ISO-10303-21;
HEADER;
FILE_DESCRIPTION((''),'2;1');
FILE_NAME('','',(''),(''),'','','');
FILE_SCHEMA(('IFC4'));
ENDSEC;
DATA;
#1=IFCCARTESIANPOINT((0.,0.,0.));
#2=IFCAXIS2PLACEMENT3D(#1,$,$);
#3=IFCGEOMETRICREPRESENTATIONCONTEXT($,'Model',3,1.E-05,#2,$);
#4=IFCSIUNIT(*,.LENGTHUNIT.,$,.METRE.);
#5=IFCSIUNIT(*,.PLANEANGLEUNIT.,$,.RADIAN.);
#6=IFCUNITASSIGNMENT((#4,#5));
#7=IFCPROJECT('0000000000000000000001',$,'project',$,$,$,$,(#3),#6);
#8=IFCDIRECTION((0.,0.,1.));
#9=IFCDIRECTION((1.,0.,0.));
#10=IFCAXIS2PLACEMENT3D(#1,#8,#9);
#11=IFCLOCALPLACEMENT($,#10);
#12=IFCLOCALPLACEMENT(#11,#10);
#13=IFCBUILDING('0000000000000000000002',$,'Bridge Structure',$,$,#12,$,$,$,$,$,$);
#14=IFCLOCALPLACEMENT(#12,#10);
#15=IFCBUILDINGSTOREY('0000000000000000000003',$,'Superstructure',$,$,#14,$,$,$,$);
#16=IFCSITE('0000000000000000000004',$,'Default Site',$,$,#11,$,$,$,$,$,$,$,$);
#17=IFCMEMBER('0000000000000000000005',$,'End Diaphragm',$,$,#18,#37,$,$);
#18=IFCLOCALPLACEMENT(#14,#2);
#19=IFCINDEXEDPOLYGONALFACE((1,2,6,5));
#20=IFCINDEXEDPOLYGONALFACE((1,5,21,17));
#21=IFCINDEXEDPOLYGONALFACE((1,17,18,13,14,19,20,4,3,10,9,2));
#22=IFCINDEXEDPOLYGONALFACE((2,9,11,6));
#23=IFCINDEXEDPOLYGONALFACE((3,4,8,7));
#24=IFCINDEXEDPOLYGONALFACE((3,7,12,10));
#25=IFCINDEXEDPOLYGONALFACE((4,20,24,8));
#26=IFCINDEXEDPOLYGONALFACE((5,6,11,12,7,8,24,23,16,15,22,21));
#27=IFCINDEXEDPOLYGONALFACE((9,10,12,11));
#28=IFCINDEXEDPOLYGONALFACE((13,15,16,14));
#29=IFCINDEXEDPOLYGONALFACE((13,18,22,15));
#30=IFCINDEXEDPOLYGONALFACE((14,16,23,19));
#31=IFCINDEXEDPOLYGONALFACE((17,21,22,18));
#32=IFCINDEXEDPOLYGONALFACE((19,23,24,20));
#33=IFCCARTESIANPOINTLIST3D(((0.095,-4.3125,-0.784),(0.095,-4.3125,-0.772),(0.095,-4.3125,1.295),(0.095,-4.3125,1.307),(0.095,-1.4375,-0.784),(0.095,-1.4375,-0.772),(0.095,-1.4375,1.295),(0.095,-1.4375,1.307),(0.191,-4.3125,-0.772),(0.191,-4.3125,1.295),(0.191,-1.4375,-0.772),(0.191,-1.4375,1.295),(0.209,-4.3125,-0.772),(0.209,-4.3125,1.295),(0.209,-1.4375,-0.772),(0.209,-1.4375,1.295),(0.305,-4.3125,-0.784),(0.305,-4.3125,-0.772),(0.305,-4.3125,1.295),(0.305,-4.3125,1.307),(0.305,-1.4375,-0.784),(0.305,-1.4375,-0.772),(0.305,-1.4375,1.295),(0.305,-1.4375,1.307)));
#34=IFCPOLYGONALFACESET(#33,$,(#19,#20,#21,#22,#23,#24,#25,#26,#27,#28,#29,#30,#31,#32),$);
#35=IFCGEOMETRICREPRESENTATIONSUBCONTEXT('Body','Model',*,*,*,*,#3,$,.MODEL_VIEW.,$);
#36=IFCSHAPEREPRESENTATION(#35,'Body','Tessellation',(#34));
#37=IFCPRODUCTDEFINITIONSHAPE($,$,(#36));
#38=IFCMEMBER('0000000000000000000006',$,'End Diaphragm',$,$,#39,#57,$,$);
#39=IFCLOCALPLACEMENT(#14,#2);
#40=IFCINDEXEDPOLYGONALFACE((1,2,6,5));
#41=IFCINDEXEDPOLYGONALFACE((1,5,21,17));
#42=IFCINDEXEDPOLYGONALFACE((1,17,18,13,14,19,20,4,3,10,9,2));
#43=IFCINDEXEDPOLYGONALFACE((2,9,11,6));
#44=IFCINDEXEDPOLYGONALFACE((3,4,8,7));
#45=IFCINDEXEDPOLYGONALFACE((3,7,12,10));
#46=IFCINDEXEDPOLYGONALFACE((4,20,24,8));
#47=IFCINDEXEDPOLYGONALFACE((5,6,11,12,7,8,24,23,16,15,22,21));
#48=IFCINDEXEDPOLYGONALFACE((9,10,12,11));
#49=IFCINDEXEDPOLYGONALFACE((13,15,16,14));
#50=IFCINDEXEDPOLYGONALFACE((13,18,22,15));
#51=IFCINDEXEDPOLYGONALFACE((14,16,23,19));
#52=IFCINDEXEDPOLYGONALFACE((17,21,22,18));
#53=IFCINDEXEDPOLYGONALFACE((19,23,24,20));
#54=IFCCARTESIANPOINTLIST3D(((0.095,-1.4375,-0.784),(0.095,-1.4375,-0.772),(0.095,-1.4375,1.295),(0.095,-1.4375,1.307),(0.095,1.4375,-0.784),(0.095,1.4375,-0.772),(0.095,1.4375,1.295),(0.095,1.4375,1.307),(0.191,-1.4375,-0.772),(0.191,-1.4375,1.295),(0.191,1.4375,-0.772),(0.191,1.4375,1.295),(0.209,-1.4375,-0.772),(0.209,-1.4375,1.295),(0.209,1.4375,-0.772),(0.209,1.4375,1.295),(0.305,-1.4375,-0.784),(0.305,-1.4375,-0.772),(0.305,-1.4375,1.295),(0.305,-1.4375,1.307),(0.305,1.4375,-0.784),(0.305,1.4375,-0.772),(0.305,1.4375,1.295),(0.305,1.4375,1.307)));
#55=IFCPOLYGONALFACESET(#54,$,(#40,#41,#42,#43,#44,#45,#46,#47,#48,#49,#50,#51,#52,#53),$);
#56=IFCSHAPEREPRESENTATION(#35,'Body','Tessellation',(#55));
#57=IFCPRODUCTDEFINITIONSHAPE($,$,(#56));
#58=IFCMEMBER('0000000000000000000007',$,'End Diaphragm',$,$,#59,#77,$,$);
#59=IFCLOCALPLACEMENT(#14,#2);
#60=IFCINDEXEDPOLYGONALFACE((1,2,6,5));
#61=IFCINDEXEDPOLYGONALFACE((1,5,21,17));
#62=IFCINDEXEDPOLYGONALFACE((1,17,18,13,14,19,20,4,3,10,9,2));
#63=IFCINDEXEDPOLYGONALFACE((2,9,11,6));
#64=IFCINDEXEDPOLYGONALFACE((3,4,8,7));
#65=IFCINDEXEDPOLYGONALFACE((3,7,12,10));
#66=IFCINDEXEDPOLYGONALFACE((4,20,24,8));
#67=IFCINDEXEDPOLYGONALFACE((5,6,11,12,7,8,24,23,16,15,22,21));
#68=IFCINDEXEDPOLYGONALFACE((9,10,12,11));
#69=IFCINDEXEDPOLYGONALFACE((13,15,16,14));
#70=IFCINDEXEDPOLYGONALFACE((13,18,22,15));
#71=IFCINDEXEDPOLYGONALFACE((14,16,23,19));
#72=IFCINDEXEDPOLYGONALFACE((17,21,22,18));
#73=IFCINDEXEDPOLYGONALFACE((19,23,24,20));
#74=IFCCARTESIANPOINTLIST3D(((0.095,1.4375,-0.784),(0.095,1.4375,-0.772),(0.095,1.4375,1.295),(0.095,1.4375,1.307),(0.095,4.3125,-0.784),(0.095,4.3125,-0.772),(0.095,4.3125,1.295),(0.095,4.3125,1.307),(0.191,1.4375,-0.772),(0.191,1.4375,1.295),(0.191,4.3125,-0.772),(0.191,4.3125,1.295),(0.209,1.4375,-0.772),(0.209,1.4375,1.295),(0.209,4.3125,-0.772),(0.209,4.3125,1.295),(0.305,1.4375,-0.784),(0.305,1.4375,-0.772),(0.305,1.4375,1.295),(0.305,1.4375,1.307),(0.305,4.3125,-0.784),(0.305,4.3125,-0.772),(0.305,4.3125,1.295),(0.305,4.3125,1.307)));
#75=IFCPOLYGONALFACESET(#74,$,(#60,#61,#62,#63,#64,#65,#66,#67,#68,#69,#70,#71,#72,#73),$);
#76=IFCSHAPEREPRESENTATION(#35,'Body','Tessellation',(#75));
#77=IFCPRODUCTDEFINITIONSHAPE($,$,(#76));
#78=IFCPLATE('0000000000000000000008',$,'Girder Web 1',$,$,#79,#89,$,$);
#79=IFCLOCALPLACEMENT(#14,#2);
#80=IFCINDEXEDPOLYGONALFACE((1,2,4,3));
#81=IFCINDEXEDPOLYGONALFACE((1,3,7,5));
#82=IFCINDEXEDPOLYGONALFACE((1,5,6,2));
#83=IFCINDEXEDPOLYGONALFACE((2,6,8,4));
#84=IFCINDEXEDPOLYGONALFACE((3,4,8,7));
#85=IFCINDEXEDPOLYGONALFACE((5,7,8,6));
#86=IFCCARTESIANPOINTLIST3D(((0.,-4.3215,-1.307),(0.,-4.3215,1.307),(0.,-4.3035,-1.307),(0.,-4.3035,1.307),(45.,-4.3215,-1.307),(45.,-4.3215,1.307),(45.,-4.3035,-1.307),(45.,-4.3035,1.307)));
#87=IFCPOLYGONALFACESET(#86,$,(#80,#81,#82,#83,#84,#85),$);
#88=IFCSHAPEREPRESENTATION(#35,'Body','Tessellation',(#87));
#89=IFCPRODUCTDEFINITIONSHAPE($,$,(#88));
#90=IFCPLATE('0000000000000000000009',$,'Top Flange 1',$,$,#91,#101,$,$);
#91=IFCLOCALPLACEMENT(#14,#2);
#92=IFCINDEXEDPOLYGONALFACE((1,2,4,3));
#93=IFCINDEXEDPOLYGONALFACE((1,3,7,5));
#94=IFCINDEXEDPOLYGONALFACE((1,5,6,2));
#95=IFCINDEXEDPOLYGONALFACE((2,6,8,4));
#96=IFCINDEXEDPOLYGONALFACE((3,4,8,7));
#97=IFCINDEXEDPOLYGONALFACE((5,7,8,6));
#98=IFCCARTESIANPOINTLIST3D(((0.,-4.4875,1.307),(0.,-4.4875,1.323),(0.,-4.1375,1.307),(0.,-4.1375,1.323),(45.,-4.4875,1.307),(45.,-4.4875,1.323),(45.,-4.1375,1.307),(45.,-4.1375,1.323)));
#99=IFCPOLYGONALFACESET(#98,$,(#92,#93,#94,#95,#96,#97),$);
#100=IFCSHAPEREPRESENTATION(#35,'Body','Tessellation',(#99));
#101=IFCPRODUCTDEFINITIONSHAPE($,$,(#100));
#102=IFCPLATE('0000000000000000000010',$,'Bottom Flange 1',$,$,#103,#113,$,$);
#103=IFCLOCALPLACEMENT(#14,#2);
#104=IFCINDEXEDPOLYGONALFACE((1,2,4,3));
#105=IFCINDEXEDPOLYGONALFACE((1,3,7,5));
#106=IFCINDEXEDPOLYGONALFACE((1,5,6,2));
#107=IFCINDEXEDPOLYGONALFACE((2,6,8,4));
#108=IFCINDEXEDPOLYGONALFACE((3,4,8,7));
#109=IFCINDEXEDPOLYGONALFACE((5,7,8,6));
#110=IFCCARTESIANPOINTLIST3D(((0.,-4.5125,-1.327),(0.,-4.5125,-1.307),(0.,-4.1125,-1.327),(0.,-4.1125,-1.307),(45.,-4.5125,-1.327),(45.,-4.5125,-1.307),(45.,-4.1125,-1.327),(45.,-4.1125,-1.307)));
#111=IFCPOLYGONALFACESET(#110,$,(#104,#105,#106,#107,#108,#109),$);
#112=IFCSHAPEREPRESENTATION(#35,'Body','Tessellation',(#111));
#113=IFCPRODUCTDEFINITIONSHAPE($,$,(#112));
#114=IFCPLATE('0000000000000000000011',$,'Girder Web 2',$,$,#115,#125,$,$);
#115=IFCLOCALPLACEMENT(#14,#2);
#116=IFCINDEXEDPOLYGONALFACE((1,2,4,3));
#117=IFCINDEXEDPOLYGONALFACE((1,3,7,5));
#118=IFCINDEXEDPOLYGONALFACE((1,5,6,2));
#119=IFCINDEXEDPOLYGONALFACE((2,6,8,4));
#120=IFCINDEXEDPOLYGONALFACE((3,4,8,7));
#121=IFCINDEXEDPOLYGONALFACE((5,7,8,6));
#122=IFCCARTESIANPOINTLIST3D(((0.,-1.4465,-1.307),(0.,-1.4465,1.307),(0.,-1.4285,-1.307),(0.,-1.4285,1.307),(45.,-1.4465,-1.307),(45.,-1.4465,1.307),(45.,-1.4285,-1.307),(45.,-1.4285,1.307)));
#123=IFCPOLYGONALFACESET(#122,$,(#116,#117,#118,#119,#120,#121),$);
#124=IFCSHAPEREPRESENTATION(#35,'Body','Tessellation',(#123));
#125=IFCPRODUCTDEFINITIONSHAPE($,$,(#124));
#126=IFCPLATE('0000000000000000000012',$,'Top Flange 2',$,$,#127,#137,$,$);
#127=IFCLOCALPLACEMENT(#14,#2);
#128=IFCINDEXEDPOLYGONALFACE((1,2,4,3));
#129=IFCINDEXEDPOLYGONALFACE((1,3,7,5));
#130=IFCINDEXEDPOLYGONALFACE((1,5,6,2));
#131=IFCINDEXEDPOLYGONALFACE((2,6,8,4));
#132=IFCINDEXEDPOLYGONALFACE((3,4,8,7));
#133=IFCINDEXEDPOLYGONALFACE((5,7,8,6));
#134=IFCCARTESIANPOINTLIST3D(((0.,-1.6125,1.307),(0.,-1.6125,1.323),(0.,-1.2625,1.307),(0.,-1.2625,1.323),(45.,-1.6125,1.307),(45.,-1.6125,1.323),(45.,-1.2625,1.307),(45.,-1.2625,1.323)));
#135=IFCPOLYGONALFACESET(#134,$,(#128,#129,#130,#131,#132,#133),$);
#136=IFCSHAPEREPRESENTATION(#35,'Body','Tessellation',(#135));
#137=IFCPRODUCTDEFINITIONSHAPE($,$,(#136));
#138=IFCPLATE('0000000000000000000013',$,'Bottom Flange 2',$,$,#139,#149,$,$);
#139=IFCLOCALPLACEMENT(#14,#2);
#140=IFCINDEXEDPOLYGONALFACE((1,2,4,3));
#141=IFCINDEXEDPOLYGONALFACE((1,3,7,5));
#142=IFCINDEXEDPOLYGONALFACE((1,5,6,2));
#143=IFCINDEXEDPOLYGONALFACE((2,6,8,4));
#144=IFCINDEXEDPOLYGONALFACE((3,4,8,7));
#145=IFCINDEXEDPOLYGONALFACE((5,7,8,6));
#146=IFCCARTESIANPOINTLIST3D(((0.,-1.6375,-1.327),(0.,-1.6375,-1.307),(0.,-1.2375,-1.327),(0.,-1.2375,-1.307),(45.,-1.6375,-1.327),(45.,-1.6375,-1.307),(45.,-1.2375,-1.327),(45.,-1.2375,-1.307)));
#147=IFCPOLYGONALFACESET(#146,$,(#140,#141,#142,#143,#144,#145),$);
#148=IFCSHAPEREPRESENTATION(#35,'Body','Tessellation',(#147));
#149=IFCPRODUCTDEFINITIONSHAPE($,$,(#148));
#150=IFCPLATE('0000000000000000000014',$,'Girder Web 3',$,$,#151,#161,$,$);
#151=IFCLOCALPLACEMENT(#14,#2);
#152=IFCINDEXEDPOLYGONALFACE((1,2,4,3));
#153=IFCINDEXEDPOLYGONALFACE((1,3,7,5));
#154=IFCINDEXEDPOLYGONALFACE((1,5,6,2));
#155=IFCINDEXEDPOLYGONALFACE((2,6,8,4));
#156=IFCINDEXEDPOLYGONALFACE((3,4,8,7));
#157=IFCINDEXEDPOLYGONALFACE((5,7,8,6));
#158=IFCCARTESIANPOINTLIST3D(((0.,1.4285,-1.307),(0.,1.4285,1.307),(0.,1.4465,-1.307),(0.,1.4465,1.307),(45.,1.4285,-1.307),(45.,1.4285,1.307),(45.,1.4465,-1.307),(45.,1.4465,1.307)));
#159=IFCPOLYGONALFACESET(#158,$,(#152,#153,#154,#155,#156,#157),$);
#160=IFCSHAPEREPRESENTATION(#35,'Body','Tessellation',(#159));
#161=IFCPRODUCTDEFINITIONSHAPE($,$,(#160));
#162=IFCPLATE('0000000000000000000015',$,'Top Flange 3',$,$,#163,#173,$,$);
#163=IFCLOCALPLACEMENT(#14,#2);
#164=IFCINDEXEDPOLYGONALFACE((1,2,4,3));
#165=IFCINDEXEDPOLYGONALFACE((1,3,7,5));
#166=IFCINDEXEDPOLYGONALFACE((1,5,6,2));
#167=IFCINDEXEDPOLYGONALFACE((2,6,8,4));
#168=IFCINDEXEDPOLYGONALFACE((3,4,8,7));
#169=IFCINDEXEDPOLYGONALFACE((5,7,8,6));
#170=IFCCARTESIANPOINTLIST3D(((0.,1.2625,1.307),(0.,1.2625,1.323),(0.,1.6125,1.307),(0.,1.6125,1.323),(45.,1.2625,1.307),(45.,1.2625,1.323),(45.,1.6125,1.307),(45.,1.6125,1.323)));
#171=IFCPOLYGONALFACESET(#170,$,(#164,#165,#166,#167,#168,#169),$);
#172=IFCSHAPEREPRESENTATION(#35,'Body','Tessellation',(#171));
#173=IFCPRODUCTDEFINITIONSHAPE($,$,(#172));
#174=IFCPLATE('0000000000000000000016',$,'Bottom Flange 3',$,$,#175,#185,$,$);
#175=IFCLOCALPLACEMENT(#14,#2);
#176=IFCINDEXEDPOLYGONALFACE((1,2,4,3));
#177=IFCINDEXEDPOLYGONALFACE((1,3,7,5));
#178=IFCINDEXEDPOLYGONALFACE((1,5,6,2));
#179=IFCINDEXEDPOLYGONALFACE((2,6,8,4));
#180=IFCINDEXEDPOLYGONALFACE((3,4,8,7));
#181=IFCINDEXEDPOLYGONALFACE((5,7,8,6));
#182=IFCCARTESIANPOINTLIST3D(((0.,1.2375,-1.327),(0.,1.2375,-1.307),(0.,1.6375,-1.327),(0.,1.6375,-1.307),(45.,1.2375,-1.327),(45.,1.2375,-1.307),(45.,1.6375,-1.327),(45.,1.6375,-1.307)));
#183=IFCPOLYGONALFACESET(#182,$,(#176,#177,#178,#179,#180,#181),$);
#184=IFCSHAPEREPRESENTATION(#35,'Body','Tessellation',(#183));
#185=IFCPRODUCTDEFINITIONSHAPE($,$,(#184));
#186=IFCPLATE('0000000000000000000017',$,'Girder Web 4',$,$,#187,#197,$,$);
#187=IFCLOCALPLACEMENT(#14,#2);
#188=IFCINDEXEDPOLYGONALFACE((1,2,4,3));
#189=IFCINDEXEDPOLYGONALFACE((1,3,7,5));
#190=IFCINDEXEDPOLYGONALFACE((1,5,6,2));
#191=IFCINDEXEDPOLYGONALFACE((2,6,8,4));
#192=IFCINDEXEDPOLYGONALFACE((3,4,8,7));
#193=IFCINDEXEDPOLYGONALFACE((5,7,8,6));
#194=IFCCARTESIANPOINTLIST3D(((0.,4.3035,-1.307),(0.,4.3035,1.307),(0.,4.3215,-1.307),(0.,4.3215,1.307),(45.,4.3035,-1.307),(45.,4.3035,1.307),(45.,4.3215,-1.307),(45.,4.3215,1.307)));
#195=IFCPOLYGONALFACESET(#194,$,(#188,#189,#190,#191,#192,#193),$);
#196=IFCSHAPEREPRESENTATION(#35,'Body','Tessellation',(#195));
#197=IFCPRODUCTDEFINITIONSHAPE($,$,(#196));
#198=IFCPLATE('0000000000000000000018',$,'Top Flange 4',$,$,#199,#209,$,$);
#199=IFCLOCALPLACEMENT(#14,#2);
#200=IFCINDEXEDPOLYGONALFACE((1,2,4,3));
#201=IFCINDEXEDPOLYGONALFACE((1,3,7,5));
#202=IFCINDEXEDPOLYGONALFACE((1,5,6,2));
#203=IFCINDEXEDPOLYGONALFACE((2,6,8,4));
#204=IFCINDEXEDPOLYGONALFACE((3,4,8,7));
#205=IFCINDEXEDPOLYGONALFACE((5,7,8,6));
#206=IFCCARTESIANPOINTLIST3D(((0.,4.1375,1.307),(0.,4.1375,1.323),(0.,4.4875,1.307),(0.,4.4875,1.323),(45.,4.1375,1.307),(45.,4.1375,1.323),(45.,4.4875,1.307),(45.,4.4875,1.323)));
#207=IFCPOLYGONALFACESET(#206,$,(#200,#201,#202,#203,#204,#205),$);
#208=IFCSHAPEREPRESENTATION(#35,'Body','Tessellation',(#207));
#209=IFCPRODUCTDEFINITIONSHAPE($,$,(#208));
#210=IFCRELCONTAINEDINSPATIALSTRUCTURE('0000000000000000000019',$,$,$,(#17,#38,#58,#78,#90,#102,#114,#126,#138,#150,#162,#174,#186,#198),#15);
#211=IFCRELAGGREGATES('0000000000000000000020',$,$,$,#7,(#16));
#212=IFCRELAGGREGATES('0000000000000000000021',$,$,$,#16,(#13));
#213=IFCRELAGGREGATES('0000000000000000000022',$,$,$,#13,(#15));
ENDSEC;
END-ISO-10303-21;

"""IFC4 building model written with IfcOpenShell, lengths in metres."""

from ifc_helpers import new_model, si_unit, frame, origin, origin_with_axes, origin_2d_with_axis, place, context, subcontext, project, spatial, rectangle, i_section, extrude, element, save


model = new_model("IFC4")

# Units and contexts
model_context = context("Model", 3, precision=1e-05, world=origin())
body_context = subcontext(model_context, "Body", "Model", "MODEL_VIEW")
ifc_project = project(units=[si_unit("LENGTHUNIT", "METRE"), si_unit("PLANEANGLEUNIT", "RADIAN")], contexts=[model_context])

# Site, building, storey
site_placement = place(None, origin_with_axes())
site = spatial("IfcSite", under=ifc_project, at=site_placement, Name="Default Site")
building_placement = place(site_placement, origin_with_axes())
building = spatial("IfcBuilding", under=site, at=building_placement, Name="Bridge Structure")
storey_placement = place(building_placement, origin_with_axes())
storey = spatial("IfcBuildingStorey", under=building, at=storey_placement, Name="Superstructure")

# Members
for number, where, z_axis, x_axis, name in (
    (1, (0.2, -4.3125, 0.2615), (0.0, 1.0, 0.0), (-1.0, 0.0, 0.0), "End Diaphragm"),
    (2, (0.2, -1.4375, 0.2615), (0.0, 1.0, 0.0), (-1.0, 0.0, 0.0), "End Diaphragm"),
    (3, (0.2, 1.4375, 0.2615), (0.0, 1.0, 0.0), (-1.0, 0.0, 0.0), "End Diaphragm"),
):
    element("IfcMember", number, at=place(storey_placement, frame(where, z_axis=z_axis, x_axis=x_axis)), inside=storey, Name=name, context=body_context, shape_type="SweptSolid", body=[
        extrude(i_section(OverallWidth=0.21, OverallDepth=2.091, WebThickness=0.018, FlangeThickness=0.012, at=origin_2d_with_axis()), origin_with_axes(), (0.0, 0.0, 1.0), 2.875),
    ])

# Plates
plate_1_placement = place(storey_placement, frame((0.0, -4.3125, 0.0), z_axis=(1.0, 0.0, 0.0), x_axis=(0.0, 1.0, 0.0)))
element("IfcPlate", 4, at=plate_1_placement, inside=storey, Name="Girder Web 1", context=body_context, shape_type="SweptSolid", body=[
    extrude(rectangle(XDim=0.018, YDim=2.614, at=origin_2d_with_axis()), origin_with_axes(), (0.0, 0.0, 1.0), 45.0),
])
plate_2_placement = place(storey_placement, frame((0.0, -4.3125, 1.315), z_axis=(1.0, 0.0, 0.0), x_axis=(0.0, 1.0, 0.0)))
element("IfcPlate", 5, at=plate_2_placement, inside=storey, Name="Top Flange 1", context=body_context, shape_type="SweptSolid", body=[
    extrude(rectangle(XDim=0.35, YDim=0.016, at=origin_2d_with_axis()), origin_with_axes(), (0.0, 0.0, 1.0), 45.0),
])
plate_3_placement = place(storey_placement, frame((0.0, -4.3125, -1.317), z_axis=(1.0, 0.0, 0.0), x_axis=(0.0, 1.0, 0.0)))
element("IfcPlate", 6, at=plate_3_placement, inside=storey, Name="Bottom Flange 1", context=body_context, shape_type="SweptSolid", body=[
    extrude(rectangle(XDim=0.4, YDim=0.02, at=origin_2d_with_axis()), origin_with_axes(), (0.0, 0.0, 1.0), 45.0),
])
plate_4_placement = place(storey_placement, frame((0.0, -1.4375, 0.0), z_axis=(1.0, 0.0, 0.0), x_axis=(0.0, 1.0, 0.0)))
element("IfcPlate", 7, at=plate_4_placement, inside=storey, Name="Girder Web 2", context=body_context, shape_type="SweptSolid", body=[
    extrude(rectangle(XDim=0.018, YDim=2.614, at=origin_2d_with_axis()), origin_with_axes(), (0.0, 0.0, 1.0), 45.0),
])
plate_5_placement = place(storey_placement, frame((0.0, -1.4375, 1.315), z_axis=(1.0, 0.0, 0.0), x_axis=(0.0, 1.0, 0.0)))
element("IfcPlate", 8, at=plate_5_placement, inside=storey, Name="Top Flange 2", context=body_context, shape_type="SweptSolid", body=[
    extrude(rectangle(XDim=0.35, YDim=0.016, at=origin_2d_with_axis()), origin_with_axes(), (0.0, 0.0, 1.0), 45.0),
])
plate_6_placement = place(storey_placement, frame((0.0, -1.4375, -1.317), z_axis=(1.0, 0.0, 0.0), x_axis=(0.0, 1.0, 0.0)))
element("IfcPlate", 9, at=plate_6_placement, inside=storey, Name="Bottom Flange 2", context=body_context, shape_type="SweptSolid", body=[
    extrude(rectangle(XDim=0.4, YDim=0.02, at=origin_2d_with_axis()), origin_with_axes(), (0.0, 0.0, 1.0), 45.0),
])
plate_7_placement = place(storey_placement, frame((0.0, 1.4375, 0.0), z_axis=(1.0, 0.0, 0.0), x_axis=(0.0, 1.0, 0.0)))
element("IfcPlate", 10, at=plate_7_placement, inside=storey, Name="Girder Web 3", context=body_context, shape_type="SweptSolid", body=[
    extrude(rectangle(XDim=0.018, YDim=2.614, at=origin_2d_with_axis()), origin_with_axes(), (0.0, 0.0, 1.0), 45.0),
])
plate_8_placement = place(storey_placement, frame((0.0, 1.4375, 1.315), z_axis=(1.0, 0.0, 0.0), x_axis=(0.0, 1.0, 0.0)))
element("IfcPlate", 11, at=plate_8_placement, inside=storey, Name="Top Flange 3", context=body_context, shape_type="SweptSolid", body=[
    extrude(rectangle(XDim=0.35, YDim=0.016, at=origin_2d_with_axis()), origin_with_axes(), (0.0, 0.0, 1.0), 45.0),
])
plate_9_placement = place(storey_placement, frame((0.0, 1.4375, -1.317), z_axis=(1.0, 0.0, 0.0), x_axis=(0.0, 1.0, 0.0)))
element("IfcPlate", 12, at=plate_9_placement, inside=storey, Name="Bottom Flange 3", context=body_context, shape_type="SweptSolid", body=[
    extrude(rectangle(XDim=0.4, YDim=0.02, at=origin_2d_with_axis()), origin_with_axes(), (0.0, 0.0, 1.0), 45.0),
])
plate_10_placement = place(storey_placement, frame((0.0, 4.3125, 0.0), z_axis=(1.0, 0.0, 0.0), x_axis=(0.0, 1.0, 0.0)))
element("IfcPlate", 13, at=plate_10_placement, inside=storey, Name="Girder Web 4", context=body_context, shape_type="SweptSolid", body=[
    extrude(rectangle(XDim=0.018, YDim=2.614, at=origin_2d_with_axis()), origin_with_axes(), (0.0, 0.0, 1.0), 45.0),
])
plate_11_placement = place(storey_placement, frame((0.0, 4.3125, 1.315), z_axis=(1.0, 0.0, 0.0), x_axis=(0.0, 1.0, 0.0)))
element("IfcPlate", 14, at=plate_11_placement, inside=storey, Name="Top Flange 4", context=body_context, shape_type="SweptSolid", body=[
    extrude(rectangle(XDim=0.35, YDim=0.016, at=origin_2d_with_axis()), origin_with_axes(), (0.0, 0.0, 1.0), 45.0),
])

save(model, "model.ifc")
